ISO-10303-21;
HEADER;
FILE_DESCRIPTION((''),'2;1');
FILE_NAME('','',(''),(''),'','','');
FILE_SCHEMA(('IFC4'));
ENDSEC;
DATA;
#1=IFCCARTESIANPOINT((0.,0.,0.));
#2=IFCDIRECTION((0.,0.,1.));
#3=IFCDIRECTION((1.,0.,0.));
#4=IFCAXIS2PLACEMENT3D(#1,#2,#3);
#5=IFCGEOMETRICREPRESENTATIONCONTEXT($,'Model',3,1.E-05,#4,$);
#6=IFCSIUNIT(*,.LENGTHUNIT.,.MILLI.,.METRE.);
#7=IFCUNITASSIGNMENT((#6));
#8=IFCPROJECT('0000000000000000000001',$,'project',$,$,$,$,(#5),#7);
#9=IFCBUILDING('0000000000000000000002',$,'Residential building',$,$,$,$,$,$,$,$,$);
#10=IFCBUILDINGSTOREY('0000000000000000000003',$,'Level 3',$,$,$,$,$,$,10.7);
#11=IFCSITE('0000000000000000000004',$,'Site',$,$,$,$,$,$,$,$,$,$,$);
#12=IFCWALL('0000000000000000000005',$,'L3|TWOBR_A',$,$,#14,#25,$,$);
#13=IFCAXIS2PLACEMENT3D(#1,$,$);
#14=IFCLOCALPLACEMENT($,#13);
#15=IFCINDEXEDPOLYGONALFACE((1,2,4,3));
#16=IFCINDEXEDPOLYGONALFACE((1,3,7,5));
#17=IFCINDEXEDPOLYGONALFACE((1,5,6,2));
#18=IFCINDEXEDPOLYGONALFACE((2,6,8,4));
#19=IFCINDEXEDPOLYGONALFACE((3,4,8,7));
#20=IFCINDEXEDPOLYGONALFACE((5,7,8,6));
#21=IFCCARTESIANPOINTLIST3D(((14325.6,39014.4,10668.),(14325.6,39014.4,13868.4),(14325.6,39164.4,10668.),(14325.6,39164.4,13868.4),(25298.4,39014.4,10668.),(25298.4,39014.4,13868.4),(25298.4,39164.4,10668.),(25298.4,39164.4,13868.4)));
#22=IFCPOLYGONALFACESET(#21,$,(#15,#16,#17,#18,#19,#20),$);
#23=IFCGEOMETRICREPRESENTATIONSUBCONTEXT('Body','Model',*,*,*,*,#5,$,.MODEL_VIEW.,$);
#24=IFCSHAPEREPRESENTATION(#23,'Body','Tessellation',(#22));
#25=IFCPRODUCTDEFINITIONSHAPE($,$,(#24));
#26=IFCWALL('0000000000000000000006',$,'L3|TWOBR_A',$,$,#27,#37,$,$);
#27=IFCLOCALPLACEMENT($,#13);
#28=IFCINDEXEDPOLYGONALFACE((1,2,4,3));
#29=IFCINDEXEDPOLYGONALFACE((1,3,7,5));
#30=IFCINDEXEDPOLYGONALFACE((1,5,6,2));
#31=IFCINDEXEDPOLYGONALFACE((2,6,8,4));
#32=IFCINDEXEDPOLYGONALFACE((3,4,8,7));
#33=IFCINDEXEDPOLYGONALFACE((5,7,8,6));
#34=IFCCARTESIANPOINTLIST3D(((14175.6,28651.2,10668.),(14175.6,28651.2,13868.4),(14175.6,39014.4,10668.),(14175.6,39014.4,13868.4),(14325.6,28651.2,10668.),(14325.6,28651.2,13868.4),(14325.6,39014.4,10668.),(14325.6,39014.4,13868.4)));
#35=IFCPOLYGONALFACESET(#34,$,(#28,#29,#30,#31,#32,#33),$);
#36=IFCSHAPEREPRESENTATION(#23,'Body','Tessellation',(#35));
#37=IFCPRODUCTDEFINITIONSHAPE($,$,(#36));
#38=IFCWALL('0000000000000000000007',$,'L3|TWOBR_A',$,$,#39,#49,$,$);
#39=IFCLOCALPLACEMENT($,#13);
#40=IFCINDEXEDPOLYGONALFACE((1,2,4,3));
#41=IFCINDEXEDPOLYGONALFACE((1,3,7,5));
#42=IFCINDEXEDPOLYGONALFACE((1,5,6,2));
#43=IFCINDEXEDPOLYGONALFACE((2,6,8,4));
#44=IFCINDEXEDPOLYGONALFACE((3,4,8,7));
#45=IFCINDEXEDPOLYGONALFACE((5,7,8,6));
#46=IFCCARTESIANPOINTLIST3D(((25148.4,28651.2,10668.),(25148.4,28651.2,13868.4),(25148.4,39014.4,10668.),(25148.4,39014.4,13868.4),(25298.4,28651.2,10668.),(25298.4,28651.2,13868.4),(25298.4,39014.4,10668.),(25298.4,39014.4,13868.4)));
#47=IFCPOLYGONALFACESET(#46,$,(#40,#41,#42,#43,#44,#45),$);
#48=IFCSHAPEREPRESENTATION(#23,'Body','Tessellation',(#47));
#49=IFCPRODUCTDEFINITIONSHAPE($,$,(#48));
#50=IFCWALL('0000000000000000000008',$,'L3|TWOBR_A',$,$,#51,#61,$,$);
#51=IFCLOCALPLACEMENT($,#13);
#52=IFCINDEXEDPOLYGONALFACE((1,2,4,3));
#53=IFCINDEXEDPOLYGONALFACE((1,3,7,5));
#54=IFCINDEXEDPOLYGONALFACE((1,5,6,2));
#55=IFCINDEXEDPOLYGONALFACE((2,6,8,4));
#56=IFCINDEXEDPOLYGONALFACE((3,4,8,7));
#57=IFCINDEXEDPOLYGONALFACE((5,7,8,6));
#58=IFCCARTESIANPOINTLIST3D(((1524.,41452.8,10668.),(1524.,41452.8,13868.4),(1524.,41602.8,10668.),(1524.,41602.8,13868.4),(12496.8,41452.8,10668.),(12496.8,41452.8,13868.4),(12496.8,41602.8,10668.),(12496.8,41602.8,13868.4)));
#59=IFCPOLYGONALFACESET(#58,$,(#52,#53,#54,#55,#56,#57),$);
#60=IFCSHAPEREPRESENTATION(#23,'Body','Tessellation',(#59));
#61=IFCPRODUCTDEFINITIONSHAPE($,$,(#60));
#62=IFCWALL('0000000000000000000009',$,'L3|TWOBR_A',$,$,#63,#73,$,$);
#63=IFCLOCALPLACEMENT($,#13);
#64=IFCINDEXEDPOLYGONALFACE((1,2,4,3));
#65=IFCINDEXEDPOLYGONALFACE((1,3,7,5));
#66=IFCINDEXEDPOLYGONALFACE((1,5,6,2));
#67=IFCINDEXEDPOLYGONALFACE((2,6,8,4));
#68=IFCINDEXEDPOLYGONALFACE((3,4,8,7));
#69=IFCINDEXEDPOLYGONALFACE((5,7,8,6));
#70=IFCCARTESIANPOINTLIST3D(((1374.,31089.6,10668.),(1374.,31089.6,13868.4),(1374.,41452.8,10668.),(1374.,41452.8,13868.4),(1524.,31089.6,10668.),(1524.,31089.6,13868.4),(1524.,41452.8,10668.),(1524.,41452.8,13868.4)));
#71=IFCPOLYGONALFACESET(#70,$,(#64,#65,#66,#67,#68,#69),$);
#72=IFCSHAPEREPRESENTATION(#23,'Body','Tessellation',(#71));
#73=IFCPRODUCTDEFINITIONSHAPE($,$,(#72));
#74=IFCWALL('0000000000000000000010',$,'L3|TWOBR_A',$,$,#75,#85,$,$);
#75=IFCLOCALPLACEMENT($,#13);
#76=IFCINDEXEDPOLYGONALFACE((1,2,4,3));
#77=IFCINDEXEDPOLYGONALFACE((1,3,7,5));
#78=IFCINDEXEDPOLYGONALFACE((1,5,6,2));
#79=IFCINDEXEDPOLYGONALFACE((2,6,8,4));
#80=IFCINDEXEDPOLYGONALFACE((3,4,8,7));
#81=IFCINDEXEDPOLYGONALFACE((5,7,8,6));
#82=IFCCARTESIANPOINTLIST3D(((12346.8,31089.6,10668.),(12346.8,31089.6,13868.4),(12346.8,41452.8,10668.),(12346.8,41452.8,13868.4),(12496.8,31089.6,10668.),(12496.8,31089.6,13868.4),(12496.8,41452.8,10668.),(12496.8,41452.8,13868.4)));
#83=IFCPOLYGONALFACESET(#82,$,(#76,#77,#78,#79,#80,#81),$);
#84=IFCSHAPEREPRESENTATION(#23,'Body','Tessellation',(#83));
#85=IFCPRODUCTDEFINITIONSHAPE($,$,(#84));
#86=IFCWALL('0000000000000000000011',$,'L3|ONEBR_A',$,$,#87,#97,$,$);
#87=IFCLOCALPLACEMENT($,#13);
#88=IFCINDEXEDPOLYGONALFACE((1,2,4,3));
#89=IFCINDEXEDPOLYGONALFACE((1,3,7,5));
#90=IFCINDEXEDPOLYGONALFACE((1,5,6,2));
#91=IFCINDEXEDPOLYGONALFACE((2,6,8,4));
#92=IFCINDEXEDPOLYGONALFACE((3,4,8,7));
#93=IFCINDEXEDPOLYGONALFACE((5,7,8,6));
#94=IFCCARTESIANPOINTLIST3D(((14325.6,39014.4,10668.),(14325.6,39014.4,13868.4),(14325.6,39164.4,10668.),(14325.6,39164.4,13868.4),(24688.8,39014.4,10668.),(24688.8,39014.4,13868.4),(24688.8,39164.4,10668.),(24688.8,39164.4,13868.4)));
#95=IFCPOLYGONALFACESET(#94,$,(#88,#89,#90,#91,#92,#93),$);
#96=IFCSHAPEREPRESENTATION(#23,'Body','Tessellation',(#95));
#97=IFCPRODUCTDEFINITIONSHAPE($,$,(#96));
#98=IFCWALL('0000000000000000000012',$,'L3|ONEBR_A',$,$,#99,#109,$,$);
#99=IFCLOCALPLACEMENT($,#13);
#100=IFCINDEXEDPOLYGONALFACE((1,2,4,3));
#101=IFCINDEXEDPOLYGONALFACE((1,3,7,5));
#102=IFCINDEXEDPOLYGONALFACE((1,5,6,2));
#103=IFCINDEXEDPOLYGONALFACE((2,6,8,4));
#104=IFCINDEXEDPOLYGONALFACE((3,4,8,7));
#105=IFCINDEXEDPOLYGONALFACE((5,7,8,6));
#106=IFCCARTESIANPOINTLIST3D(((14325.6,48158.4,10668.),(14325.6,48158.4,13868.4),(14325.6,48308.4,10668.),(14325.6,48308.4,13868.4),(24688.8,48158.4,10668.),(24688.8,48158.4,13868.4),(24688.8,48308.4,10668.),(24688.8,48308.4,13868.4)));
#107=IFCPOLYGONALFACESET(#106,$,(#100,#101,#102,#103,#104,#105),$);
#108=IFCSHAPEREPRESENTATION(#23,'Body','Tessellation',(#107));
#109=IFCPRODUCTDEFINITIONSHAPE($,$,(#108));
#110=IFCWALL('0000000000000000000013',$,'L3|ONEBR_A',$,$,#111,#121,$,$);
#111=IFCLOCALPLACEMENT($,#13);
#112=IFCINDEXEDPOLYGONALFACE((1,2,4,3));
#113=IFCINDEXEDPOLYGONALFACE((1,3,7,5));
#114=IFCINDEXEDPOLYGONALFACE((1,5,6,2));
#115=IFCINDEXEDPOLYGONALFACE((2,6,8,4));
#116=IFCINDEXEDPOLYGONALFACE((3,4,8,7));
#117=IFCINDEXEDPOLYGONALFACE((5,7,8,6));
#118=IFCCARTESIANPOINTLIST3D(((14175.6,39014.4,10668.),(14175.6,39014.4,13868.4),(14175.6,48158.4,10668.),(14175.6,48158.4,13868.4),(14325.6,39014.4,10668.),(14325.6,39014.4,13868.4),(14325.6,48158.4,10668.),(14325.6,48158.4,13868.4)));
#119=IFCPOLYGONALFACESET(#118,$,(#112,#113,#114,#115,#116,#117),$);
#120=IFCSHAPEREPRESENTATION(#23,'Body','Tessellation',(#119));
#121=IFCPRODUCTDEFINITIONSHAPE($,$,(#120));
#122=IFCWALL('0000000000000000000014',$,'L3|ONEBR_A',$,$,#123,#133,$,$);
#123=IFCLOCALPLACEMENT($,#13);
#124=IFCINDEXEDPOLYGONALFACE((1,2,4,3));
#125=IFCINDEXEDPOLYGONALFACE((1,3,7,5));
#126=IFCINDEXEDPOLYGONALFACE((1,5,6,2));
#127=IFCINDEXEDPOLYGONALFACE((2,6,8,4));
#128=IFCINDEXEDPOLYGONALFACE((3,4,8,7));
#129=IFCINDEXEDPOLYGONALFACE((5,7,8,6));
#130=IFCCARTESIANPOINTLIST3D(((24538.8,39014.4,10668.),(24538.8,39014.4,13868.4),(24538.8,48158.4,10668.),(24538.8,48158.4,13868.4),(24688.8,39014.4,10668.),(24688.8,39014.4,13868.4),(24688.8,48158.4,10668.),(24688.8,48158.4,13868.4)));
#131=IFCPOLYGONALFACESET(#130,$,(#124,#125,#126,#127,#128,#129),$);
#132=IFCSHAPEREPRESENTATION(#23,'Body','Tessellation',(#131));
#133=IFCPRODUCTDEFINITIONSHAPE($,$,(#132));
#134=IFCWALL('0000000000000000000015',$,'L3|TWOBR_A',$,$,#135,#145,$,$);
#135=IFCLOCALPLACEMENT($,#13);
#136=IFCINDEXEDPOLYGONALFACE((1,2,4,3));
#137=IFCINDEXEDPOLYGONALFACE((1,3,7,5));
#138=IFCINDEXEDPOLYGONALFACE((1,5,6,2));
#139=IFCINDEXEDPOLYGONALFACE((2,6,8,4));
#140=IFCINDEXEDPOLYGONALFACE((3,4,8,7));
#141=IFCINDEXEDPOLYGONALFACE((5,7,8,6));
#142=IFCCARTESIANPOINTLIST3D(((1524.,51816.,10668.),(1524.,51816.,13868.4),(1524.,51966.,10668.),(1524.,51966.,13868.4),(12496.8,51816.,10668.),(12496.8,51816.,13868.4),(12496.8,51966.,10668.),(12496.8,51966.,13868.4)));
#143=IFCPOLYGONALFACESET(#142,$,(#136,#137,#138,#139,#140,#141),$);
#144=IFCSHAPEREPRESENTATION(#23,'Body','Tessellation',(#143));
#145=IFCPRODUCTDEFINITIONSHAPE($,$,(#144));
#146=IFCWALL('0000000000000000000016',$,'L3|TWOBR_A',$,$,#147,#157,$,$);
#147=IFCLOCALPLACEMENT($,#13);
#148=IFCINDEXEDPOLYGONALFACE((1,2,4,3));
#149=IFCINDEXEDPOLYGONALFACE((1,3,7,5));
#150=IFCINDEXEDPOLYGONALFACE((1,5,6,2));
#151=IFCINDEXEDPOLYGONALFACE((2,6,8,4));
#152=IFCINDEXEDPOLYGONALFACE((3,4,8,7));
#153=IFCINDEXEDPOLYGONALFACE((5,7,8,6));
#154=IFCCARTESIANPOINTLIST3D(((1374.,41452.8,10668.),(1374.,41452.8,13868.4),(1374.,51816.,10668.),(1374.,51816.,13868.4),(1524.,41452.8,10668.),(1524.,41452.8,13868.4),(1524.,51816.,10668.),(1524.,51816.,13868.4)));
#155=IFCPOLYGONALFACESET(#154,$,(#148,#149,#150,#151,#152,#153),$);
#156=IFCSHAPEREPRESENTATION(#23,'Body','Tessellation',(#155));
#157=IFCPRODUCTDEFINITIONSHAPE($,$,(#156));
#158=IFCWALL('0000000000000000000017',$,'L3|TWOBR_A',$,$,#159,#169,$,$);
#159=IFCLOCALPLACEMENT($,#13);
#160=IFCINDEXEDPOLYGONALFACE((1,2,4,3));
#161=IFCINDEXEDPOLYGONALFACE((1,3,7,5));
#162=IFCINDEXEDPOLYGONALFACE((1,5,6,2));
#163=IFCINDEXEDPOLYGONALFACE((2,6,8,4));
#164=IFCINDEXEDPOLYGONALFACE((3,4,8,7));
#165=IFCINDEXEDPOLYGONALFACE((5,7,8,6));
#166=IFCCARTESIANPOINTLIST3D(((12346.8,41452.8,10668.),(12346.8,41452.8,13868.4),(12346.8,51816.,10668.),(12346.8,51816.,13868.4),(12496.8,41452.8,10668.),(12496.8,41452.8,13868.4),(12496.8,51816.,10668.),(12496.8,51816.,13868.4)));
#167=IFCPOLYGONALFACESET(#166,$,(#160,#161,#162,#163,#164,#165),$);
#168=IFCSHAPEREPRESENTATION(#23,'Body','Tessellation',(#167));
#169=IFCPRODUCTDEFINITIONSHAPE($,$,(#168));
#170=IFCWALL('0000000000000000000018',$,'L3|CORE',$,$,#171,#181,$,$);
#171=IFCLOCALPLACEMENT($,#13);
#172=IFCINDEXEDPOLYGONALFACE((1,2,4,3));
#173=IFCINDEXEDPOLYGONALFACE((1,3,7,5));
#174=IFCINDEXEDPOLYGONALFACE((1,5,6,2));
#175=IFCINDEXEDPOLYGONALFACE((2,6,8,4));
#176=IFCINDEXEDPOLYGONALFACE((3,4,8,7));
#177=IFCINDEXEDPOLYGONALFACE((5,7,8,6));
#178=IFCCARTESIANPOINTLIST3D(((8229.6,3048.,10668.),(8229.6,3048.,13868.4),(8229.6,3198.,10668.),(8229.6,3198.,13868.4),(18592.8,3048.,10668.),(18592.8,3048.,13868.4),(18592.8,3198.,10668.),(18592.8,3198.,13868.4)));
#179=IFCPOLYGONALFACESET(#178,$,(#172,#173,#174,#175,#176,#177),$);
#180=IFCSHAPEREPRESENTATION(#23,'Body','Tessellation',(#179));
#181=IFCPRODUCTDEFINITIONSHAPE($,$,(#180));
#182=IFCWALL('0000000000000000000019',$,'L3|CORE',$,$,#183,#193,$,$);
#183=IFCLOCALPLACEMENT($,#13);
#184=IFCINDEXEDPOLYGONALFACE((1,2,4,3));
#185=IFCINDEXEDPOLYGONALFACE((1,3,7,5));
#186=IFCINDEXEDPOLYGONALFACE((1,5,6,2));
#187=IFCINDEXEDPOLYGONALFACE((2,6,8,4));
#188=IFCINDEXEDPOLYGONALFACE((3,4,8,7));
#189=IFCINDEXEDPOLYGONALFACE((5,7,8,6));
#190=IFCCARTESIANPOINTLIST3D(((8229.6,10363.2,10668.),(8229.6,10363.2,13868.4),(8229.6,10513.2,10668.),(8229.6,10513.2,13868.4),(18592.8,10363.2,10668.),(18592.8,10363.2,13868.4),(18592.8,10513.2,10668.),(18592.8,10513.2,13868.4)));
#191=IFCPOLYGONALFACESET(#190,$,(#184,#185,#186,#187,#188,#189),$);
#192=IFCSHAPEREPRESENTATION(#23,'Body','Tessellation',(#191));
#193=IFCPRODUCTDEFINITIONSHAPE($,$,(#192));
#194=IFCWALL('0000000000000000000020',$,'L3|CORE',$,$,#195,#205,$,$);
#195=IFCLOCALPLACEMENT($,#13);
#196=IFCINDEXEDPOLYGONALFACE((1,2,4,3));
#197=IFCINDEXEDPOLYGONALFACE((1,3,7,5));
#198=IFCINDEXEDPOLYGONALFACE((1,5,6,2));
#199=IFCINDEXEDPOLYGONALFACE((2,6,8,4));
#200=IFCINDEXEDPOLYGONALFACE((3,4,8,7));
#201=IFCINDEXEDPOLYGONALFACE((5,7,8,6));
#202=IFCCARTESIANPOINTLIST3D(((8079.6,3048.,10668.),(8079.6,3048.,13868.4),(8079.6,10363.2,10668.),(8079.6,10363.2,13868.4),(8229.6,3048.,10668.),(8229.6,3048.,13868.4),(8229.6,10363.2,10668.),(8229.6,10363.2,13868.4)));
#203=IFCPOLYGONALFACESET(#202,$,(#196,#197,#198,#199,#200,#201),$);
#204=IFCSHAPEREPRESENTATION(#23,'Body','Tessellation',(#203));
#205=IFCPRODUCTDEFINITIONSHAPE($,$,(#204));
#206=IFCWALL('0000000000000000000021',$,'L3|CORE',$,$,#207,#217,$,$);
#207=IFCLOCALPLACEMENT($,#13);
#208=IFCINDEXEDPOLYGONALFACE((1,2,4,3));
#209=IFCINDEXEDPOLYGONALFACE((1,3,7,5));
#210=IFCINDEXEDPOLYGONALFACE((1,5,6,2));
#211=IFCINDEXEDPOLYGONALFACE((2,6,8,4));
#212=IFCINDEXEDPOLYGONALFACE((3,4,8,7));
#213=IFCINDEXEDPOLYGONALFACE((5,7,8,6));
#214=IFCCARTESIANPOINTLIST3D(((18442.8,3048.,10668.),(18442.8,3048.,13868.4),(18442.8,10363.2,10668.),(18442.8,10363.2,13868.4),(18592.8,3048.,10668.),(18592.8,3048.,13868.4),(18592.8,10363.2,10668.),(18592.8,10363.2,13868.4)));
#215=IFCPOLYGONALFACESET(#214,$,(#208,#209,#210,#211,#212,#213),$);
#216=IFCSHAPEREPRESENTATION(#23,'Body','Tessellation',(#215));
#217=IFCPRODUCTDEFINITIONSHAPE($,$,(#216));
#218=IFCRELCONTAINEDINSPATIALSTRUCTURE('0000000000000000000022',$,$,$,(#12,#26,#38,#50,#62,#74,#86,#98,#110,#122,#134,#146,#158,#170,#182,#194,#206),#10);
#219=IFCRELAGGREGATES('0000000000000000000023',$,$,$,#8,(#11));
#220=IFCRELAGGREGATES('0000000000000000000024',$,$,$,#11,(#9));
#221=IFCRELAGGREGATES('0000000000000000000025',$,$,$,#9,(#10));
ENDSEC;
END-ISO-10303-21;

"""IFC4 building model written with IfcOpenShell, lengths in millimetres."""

from ifc_helpers import new_model, si_unit, frame, origin_with_axes, place, context, subcontext, project, spatial, indexed_curve, outline, extrude, element, save


model = new_model("IFC4")

# Units and contexts
model_context = context("Model", 3, precision=1e-05, world=origin_with_axes())
body_context = subcontext(model_context, "Body", "Model", "MODEL_VIEW")
ifc_project = project(units=[si_unit("LENGTHUNIT", "METRE", prefix="MILLI")], contexts=[model_context])

# Site, building, storey
site = spatial("IfcSite", under=ifc_project, Name="Site")
building = spatial("IfcBuilding", under=site, Name="Residential building")
storey = spatial("IfcBuildingStorey", under=building, Name="Level 3", Elevation=10.7)

# Walls
for number, where, z_axis, x_axis, name in (
    (1, (14325.6, 39014.4, 10668.0), (0.0, 0.0, 1.0), (1.0, 0.0, 0.0), "L3|TWOBR_A"),
):
    element("IfcWall", number, at=place(None, frame(where, z_axis=z_axis, x_axis=x_axis)), inside=storey, Name=name, context=body_context, shape_type="SweptSolid", body=[
        extrude(outline(indexed_curve([(0.0, 0.0), (0.0, 150.0), (10972.8, 150.0), (10972.8, 0.0), (0.0, 0.0)], self_intersect=False)), origin_with_axes(), (0.0, 0.0, 1.0), 3200.4),
    ])
for number, where, z_axis, x_axis, name in (
    (2, (14325.6, 28651.2, 10668.0), (0.0, 0.0, 1.0), (0.0, 1.0, 0.0), "L3|TWOBR_A"),
    (3, (25298.4, 28651.2, 10668.0), (0.0, 0.0, 1.0), (0.0, 1.0, 0.0), "L3|TWOBR_A"),
):
    element("IfcWall", number, at=place(None, frame(where, z_axis=z_axis, x_axis=x_axis)), inside=storey, Name=name, context=body_context, shape_type="SweptSolid", body=[
        extrude(outline(indexed_curve([(0.0, 0.0), (0.0, 150.0), (10363.2, 150.0), (10363.2, 0.0), (0.0, 0.0)], self_intersect=False)), origin_with_axes(), (0.0, 0.0, 1.0), 3200.4),
    ])
for number, where, z_axis, x_axis, name in (
    (4, (1524.0, 41452.8, 10668.0), (0.0, 0.0, 1.0), (1.0, 0.0, 0.0), "L3|TWOBR_A"),
):
    element("IfcWall", number, at=place(None, frame(where, z_axis=z_axis, x_axis=x_axis)), inside=storey, Name=name, context=body_context, shape_type="SweptSolid", body=[
        extrude(outline(indexed_curve([(0.0, 0.0), (0.0, 150.0), (10972.8, 150.0), (10972.8, 0.0), (0.0, 0.0)], self_intersect=False)), origin_with_axes(), (0.0, 0.0, 1.0), 3200.4),
    ])
for number, where, z_axis, x_axis, name in (
    (5, (1524.0, 31089.6, 10668.0), (0.0, 0.0, 1.0), (0.0, 1.0, 0.0), "L3|TWOBR_A"),
    (6, (12496.8, 31089.6, 10668.0), (0.0, 0.0, 1.0), (0.0, 1.0, 0.0), "L3|TWOBR_A"),
    (7, (14325.6, 39014.4, 10668.0), (0.0, 0.0, 1.0), (1.0, 0.0, 0.0), "L3|ONEBR_A"),
    (8, (14325.6, 48158.4, 10668.0), (0.0, 0.0, 1.0), (1.0, 0.0, 0.0), "L3|ONEBR_A"),
):
    element("IfcWall", number, at=place(None, frame(where, z_axis=z_axis, x_axis=x_axis)), inside=storey, Name=name, context=body_context, shape_type="SweptSolid", body=[
        extrude(outline(indexed_curve([(0.0, 0.0), (0.0, 150.0), (10363.2, 150.0), (10363.2, 0.0), (0.0, 0.0)], self_intersect=False)), origin_with_axes(), (0.0, 0.0, 1.0), 3200.4),
    ])
for number, where, z_axis, x_axis, name in (
    (9, (14325.6, 39014.4, 10668.0), (0.0, 0.0, 1.0), (0.0, 1.0, 0.0), "L3|ONEBR_A"),
    (10, (24688.8, 39014.4, 10668.0), (0.0, 0.0, 1.0), (0.0, 1.0, 0.0), "L3|ONEBR_A"),
):
    element("IfcWall", number, at=place(None, frame(where, z_axis=z_axis, x_axis=x_axis)), inside=storey, Name=name, context=body_context, shape_type="SweptSolid", body=[
        extrude(outline(indexed_curve([(0.0, 0.0), (0.0, 150.0), (9144.0, 150.0), (9144.0, 0.0), (0.0, 0.0)], self_intersect=False)), origin_with_axes(), (0.0, 0.0, 1.0), 3200.4),
    ])
for number, where, z_axis, x_axis, name in (
    (11, (1524.0, 51816.0, 10668.0), (0.0, 0.0, 1.0), (1.0, 0.0, 0.0), "L3|TWOBR_A"),
):
    element("IfcWall", number, at=place(None, frame(where, z_axis=z_axis, x_axis=x_axis)), inside=storey, Name=name, context=body_context, shape_type="SweptSolid", body=[
        extrude(outline(indexed_curve([(0.0, 0.0), (0.0, 150.0), (10972.8, 150.0), (10972.8, 0.0), (0.0, 0.0)], self_intersect=False)), origin_with_axes(), (0.0, 0.0, 1.0), 3200.4),
    ])
for number, where, z_axis, x_axis, name in (
    (12, (1524.0, 41452.8, 10668.0), (0.0, 0.0, 1.0), (0.0, 1.0, 0.0), "L3|TWOBR_A"),
    (13, (12496.8, 41452.8, 10668.0), (0.0, 0.0, 1.0), (0.0, 1.0, 0.0), "L3|TWOBR_A"),
    (14, (8229.6, 3048.0, 10668.0), (0.0, 0.0, 1.0), (1.0, 0.0, 0.0), "L3|CORE"),
    (15, (8229.6, 10363.2, 10668.0), (0.0, 0.0, 1.0), (1.0, 0.0, 0.0), "L3|CORE"),
):
    element("IfcWall", number, at=place(None, frame(where, z_axis=z_axis, x_axis=x_axis)), inside=storey, Name=name, context=body_context, shape_type="SweptSolid", body=[
        extrude(outline(indexed_curve([(0.0, 0.0), (0.0, 150.0), (10363.2, 150.0), (10363.2, 0.0), (0.0, 0.0)], self_intersect=False)), origin_with_axes(), (0.0, 0.0, 1.0), 3200.4),
    ])
for number, where, z_axis, x_axis, name in (
    (16, (8229.6, 3048.0, 10668.0), (0.0, 0.0, 1.0), (0.0, 1.0, 0.0), "L3|CORE"),
    (17, (18592.8, 3048.0, 10668.0), (0.0, 0.0, 1.0), (0.0, 1.0, 0.0), "L3|CORE"),
):
    element("IfcWall", number, at=place(None, frame(where, z_axis=z_axis, x_axis=x_axis)), inside=storey, Name=name, context=body_context, shape_type="SweptSolid", body=[
        extrude(outline(indexed_curve([(0.0, 0.0), (0.0, 150.0), (7315.2, 150.0), (7315.2, 0.0), (0.0, 0.0)], self_intersect=False)), origin_with_axes(), (0.0, 0.0, 1.0), 3200.4),
    ])

save(model, "model.ifc")
